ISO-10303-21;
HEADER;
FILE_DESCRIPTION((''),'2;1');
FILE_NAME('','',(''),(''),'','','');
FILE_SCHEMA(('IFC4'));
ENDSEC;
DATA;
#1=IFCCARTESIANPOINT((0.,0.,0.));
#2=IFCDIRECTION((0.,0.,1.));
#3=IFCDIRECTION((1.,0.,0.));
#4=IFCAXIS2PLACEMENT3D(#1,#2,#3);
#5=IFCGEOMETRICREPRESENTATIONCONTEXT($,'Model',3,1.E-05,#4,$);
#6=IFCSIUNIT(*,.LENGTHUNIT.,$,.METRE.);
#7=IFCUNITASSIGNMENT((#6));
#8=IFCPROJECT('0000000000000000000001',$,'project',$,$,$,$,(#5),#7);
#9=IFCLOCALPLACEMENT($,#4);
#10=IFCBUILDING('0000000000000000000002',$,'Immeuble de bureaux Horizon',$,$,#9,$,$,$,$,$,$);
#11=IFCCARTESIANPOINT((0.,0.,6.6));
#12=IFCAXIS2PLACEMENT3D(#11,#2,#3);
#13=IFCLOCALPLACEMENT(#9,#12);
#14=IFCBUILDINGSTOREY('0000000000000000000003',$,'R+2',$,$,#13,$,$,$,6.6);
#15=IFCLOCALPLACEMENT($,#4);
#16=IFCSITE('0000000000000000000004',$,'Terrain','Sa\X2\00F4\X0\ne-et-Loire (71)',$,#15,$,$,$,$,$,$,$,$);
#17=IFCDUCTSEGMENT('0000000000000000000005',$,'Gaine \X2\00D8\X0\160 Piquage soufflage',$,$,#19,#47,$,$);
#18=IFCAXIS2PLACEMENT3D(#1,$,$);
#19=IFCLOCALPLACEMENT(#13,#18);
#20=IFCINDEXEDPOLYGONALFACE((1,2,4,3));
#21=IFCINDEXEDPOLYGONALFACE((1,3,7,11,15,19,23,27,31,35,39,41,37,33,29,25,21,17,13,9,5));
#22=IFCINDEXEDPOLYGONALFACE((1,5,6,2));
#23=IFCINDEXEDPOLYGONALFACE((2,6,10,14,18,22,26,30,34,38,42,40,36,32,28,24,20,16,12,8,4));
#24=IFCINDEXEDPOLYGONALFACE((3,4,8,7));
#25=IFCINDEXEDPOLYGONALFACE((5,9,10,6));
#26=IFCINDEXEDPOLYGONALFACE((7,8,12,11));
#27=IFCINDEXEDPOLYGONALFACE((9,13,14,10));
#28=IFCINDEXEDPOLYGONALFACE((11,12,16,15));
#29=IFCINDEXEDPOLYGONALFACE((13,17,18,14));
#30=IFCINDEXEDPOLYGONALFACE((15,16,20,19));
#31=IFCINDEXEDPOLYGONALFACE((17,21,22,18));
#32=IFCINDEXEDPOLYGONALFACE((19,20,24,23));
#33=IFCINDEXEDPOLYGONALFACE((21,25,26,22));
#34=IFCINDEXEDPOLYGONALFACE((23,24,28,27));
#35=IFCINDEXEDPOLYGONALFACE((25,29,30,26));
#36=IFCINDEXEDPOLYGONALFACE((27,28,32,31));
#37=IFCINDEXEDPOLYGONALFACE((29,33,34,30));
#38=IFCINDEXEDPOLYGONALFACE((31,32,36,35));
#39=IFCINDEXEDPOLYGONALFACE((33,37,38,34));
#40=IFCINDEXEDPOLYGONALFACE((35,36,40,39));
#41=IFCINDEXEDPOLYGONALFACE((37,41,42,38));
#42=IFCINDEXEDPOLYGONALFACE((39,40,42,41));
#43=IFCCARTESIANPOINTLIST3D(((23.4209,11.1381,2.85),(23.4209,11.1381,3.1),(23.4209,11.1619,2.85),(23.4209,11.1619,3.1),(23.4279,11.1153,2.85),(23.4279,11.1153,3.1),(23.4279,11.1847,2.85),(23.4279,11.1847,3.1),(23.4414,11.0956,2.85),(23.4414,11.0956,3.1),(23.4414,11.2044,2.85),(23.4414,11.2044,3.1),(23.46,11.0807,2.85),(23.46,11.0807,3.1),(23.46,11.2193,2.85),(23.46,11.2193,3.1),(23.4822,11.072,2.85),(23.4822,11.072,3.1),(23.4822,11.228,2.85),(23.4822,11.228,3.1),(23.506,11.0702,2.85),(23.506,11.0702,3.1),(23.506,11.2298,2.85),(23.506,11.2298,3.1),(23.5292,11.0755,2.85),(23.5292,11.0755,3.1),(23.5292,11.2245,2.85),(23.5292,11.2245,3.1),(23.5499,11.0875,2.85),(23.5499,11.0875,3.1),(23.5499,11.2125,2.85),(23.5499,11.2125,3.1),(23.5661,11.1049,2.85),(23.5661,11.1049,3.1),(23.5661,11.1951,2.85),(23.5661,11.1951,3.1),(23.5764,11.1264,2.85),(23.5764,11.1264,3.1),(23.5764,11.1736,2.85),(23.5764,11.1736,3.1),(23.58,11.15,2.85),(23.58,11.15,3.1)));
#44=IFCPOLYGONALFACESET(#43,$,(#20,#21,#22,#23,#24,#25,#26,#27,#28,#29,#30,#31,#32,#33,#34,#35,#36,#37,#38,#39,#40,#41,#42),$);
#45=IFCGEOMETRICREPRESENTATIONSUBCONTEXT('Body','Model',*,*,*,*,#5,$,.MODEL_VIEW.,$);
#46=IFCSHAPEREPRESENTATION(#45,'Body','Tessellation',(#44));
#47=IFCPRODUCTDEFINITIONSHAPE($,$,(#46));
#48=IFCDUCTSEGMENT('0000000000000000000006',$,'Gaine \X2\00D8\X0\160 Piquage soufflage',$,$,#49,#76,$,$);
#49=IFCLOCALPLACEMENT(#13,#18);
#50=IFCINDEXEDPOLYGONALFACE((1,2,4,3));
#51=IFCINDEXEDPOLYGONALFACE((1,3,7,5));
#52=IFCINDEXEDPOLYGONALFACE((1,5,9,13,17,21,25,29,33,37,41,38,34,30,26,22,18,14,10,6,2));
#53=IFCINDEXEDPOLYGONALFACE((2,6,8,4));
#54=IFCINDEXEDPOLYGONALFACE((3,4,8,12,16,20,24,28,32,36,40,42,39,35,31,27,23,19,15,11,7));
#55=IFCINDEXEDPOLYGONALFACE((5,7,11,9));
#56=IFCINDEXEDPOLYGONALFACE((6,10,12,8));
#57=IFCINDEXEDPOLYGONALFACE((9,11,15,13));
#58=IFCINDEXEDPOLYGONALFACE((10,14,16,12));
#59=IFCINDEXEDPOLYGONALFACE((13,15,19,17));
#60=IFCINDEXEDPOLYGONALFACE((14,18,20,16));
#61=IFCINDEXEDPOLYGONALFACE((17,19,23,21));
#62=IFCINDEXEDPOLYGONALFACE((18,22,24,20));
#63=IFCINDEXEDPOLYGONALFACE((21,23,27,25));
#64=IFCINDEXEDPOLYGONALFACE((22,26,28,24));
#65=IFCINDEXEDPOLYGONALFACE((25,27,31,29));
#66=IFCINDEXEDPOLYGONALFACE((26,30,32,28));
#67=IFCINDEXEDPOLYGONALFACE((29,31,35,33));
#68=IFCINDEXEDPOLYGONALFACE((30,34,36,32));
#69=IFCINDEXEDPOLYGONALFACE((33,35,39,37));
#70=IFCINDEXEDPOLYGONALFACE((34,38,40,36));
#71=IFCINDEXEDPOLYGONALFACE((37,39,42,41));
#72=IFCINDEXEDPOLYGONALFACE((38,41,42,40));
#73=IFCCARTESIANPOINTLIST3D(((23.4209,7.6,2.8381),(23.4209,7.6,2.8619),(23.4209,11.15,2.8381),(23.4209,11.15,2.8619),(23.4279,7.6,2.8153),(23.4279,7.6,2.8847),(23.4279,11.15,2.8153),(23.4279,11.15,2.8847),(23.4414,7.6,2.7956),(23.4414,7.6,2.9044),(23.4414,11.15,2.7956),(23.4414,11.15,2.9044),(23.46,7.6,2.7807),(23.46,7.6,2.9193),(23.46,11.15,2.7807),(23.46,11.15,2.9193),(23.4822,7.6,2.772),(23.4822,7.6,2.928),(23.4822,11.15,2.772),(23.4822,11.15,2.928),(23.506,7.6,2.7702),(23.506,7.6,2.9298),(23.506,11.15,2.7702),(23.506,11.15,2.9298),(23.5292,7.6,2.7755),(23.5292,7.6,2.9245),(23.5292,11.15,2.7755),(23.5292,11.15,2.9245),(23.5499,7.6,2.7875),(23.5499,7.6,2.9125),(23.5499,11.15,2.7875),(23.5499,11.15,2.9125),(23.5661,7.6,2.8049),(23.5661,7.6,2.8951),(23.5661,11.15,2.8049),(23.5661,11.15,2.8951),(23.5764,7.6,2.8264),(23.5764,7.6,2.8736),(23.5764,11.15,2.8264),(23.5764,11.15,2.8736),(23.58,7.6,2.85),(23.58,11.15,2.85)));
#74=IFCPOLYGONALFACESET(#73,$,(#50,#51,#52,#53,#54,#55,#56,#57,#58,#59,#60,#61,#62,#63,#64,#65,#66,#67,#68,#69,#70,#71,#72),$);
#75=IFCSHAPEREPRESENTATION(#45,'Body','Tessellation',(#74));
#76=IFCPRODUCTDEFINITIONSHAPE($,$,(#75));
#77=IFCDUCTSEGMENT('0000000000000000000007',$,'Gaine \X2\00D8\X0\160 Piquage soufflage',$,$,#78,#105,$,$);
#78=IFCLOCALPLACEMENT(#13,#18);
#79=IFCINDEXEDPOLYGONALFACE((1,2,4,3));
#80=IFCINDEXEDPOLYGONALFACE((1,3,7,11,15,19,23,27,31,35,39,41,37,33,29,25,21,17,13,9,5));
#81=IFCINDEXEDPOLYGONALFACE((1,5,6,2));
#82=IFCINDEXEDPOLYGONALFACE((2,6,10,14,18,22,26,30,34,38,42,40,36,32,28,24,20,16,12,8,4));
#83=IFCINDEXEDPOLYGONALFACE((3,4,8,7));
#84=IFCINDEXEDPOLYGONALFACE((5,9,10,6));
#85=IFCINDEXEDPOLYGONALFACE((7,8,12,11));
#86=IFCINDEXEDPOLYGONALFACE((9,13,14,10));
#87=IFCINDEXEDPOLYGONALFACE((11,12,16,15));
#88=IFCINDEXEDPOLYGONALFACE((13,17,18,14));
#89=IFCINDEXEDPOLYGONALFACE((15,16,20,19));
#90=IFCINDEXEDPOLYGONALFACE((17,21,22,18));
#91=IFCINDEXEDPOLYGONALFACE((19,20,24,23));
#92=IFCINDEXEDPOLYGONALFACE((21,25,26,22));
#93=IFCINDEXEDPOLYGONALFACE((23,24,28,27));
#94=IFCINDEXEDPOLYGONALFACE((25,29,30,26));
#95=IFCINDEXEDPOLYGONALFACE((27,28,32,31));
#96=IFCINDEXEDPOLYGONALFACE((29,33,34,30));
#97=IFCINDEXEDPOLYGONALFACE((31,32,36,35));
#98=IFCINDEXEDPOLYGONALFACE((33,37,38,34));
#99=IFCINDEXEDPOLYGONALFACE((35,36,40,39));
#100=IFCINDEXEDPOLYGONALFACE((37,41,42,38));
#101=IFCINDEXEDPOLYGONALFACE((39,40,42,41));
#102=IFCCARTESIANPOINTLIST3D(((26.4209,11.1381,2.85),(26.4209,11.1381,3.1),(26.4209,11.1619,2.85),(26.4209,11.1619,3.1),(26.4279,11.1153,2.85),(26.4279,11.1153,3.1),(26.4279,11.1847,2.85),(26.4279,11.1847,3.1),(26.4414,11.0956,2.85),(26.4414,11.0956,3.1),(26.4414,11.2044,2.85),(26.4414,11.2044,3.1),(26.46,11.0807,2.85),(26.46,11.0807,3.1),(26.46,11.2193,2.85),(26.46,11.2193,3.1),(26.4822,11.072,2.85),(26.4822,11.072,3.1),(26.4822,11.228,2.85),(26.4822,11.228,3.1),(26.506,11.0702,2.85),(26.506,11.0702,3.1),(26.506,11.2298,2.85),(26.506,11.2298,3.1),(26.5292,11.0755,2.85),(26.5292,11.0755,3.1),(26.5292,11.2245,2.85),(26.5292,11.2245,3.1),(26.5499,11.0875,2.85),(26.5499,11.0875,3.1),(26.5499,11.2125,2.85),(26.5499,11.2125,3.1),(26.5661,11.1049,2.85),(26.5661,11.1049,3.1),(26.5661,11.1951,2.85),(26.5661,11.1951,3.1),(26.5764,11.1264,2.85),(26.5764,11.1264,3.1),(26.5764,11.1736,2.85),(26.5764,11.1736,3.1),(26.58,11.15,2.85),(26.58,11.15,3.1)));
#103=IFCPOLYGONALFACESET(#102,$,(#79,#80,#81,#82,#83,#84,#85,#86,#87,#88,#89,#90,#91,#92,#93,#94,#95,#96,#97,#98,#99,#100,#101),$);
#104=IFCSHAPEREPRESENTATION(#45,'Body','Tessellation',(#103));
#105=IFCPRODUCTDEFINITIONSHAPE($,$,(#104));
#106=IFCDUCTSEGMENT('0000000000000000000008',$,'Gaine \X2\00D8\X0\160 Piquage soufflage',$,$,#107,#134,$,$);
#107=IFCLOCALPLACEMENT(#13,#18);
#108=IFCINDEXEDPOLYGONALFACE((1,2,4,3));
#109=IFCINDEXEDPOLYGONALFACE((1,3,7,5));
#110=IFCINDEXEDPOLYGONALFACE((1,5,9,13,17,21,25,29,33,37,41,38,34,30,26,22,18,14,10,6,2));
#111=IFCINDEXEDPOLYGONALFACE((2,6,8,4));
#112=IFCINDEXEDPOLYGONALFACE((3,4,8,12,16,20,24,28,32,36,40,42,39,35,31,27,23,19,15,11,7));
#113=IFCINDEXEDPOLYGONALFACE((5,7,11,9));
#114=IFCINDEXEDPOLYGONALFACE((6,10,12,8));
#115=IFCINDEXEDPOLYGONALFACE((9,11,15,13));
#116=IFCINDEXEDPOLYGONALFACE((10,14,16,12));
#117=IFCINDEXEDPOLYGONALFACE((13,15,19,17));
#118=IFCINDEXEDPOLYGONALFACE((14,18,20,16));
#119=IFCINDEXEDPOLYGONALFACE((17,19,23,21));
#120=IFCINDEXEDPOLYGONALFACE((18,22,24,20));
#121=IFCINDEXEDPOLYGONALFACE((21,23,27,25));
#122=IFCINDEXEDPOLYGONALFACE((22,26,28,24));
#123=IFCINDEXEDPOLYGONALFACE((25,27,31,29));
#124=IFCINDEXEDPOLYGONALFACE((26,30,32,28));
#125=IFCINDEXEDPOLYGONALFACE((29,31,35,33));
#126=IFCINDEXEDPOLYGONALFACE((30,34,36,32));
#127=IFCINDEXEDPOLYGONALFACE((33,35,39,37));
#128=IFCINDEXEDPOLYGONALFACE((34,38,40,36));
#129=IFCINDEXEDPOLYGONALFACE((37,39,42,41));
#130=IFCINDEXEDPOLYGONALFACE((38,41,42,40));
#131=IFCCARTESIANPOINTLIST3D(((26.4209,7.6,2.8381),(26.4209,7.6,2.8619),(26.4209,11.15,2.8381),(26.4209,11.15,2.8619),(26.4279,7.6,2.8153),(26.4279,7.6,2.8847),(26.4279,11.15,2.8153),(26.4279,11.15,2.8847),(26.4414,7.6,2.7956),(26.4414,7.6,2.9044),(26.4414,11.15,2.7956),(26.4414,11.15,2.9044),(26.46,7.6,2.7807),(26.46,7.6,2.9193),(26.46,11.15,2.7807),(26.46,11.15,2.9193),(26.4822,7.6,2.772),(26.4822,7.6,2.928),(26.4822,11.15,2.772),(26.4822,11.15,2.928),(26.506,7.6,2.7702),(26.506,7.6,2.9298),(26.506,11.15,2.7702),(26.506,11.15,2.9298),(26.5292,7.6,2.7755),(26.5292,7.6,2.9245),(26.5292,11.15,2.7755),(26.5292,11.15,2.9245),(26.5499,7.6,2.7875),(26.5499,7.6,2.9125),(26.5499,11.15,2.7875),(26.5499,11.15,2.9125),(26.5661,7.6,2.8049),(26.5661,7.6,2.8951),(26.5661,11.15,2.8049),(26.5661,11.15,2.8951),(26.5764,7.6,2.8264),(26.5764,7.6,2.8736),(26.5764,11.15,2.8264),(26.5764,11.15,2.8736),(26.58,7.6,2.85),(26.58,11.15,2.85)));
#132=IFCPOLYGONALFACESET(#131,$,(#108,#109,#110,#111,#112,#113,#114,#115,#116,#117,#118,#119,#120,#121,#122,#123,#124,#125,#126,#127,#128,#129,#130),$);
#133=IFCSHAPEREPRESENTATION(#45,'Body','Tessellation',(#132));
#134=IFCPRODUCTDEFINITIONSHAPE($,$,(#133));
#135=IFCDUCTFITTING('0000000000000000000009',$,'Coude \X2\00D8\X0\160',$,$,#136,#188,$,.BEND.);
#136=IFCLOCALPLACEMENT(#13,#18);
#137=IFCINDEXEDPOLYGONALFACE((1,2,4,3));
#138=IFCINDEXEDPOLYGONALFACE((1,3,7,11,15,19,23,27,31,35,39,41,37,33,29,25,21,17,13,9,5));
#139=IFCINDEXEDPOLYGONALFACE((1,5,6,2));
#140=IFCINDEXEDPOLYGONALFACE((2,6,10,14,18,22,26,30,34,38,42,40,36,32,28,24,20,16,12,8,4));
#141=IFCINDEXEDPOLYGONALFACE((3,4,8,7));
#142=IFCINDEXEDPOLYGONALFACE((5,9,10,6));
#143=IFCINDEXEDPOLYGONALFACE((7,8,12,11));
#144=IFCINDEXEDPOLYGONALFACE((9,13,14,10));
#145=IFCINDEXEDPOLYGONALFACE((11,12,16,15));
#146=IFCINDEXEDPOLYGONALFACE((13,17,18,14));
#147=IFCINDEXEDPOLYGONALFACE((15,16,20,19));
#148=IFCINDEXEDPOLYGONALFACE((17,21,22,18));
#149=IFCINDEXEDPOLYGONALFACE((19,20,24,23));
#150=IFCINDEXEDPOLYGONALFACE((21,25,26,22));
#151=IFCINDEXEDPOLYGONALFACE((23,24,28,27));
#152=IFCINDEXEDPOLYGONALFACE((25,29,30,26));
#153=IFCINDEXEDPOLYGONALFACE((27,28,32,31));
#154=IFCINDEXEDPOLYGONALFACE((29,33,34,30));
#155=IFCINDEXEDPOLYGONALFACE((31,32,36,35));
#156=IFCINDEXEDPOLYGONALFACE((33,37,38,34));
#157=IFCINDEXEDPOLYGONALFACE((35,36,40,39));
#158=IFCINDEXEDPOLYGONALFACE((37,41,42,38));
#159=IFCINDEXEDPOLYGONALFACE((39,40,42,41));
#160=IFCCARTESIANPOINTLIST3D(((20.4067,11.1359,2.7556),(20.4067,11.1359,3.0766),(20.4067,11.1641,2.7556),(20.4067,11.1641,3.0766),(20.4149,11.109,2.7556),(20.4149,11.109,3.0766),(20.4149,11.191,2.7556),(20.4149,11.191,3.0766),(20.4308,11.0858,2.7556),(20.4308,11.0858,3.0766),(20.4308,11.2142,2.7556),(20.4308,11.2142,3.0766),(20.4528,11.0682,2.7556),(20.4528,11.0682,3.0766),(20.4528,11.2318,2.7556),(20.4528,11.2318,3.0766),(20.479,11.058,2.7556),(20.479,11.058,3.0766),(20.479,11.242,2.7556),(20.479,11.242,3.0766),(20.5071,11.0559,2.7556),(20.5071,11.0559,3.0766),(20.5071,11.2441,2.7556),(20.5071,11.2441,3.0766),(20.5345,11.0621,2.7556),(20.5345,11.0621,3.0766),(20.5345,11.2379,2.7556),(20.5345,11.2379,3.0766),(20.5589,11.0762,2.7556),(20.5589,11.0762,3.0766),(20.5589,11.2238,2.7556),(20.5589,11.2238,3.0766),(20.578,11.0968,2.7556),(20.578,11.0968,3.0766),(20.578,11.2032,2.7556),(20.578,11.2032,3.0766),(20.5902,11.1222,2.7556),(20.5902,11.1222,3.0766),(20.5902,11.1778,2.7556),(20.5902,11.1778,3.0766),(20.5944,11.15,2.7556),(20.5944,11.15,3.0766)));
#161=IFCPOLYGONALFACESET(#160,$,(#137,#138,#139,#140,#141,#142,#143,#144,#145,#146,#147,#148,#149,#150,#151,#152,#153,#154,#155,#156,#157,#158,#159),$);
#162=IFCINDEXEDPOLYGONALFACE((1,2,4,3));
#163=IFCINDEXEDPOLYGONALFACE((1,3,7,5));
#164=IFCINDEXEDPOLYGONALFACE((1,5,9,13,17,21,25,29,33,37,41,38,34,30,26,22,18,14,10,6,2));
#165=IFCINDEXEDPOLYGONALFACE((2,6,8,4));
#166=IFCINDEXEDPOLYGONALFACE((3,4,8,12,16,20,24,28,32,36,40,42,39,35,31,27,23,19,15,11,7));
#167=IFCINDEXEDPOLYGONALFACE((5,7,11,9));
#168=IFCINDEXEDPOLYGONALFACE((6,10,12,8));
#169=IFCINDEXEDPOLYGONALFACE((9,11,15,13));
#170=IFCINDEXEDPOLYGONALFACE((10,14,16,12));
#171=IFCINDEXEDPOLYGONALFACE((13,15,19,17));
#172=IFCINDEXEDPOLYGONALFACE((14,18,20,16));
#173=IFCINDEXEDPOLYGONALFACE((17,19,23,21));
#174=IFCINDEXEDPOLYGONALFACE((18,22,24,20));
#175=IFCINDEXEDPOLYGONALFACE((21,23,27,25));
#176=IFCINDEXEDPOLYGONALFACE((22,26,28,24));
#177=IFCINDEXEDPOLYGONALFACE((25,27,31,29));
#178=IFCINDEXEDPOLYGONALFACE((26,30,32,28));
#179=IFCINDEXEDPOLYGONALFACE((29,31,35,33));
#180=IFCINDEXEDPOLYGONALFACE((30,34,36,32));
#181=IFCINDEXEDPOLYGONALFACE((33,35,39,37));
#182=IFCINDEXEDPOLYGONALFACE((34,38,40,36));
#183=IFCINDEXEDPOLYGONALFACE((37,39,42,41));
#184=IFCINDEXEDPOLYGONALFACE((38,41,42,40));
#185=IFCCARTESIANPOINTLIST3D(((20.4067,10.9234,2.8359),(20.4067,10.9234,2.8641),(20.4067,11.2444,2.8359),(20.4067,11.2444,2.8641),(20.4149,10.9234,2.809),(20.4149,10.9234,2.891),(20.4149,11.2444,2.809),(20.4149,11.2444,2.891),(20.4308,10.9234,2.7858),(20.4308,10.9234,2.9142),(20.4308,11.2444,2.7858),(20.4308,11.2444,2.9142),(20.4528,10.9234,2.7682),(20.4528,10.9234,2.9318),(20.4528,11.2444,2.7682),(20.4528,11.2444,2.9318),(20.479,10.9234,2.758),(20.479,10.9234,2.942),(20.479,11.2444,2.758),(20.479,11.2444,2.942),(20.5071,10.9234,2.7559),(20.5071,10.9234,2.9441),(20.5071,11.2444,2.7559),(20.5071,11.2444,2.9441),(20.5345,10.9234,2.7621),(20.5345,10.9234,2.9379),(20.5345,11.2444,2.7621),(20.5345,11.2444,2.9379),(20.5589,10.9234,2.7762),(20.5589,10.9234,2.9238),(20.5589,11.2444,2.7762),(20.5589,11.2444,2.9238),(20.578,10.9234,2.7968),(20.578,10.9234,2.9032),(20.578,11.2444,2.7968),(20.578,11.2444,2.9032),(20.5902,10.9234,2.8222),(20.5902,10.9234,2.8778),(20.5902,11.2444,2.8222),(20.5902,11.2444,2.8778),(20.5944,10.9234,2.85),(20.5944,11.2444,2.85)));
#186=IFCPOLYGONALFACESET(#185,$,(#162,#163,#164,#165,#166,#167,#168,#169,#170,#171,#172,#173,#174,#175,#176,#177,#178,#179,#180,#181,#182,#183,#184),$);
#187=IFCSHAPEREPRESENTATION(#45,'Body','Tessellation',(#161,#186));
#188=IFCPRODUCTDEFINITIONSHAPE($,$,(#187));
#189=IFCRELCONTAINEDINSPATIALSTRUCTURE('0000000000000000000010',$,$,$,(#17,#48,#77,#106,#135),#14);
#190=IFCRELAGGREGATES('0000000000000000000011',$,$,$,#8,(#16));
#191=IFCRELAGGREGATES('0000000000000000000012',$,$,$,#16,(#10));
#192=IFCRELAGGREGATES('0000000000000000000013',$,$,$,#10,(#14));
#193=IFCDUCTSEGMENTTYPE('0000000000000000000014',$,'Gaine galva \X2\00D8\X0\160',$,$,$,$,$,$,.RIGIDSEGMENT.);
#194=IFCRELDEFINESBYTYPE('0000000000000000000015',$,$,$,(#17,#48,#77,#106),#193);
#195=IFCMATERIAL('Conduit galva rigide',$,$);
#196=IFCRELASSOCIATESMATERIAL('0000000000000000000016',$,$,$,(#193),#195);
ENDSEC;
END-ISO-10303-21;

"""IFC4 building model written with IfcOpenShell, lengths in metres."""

from ifc_helpers import new_model, si_unit, frame, origin_with_axes, place, context, subcontext, project, spatial, circle, extrude, material, type_object, element, save


model = new_model("IFC4")

# Units and contexts
model_context = context("Model", 3, precision=1e-05, world=origin_with_axes())
body_context = subcontext(model_context, "Body", "Model", "MODEL_VIEW")
ifc_project = project(units=[si_unit("LENGTHUNIT", "METRE")], contexts=[model_context])

# Site, building, storey
site_placement = place(None, origin_with_axes())
site = spatial("IfcSite", under=ifc_project, at=site_placement, Name="Terrain", Description="Saône-et-Loire (71)")
building_placement = place(None, origin_with_axes())
building = spatial("IfcBuilding", under=site, at=building_placement, Name="Immeuble de bureaux Horizon")
storey_placement = place(building_placement, frame((0.0, 0.0, 6.6), z_axis=(0.0, 0.0, 1.0), x_axis=(1.0, 0.0, 0.0)))
storey = spatial("IfcBuildingStorey", under=building, at=storey_placement, Name="R+2", Elevation=6.6)

# Duct segments
ifc_material_1 = material(Name="Conduit galva rigide")
duct_segment_type = type_object("IfcDuctSegmentType", Name="Gaine galva Ø160", PredefinedType="RIGIDSEGMENT", material=ifc_material_1)
duct_segment_1_placement = place(storey_placement, frame((23.5, 11.15, 3.1), z_axis=(0.0, 0.0, -1.0), x_axis=(1.0, 0.0, 0.0)))
element("IfcDuctSegment", 1, at=duct_segment_1_placement, inside=storey, type_object=duct_segment_type, Name="Gaine Ø160 Piquage soufflage", context=body_context, shape_type="SweptSolid", body=[
    extrude(circle(Radius=0.08), origin_with_axes(), (0.0, 0.0, 1.0), 0.25),
])
duct_segment_2_placement = place(storey_placement, frame((23.5, 11.15, 2.85), z_axis=(0.0, -1.0, 0.0), x_axis=(1.0, 0.0, 0.0)))
element("IfcDuctSegment", 2, at=duct_segment_2_placement, inside=storey, type_object=duct_segment_type, Name="Gaine Ø160 Piquage soufflage", context=body_context, shape_type="SweptSolid", body=[
    extrude(circle(Radius=0.08), origin_with_axes(), (0.0, 0.0, 1.0), 3.55),
])
duct_segment_3_placement = place(storey_placement, frame((26.5, 11.15, 3.1), z_axis=(0.0, 0.0, -1.0), x_axis=(1.0, 0.0, 0.0)))
element("IfcDuctSegment", 3, at=duct_segment_3_placement, inside=storey, type_object=duct_segment_type, Name="Gaine Ø160 Piquage soufflage", context=body_context, shape_type="SweptSolid", body=[
    extrude(circle(Radius=0.08), origin_with_axes(), (0.0, 0.0, 1.0), 0.25),
])
duct_segment_4_placement = place(storey_placement, frame((26.5, 11.15, 2.85), z_axis=(0.0, -1.0, 0.0), x_axis=(1.0, 0.0, 0.0)))
element("IfcDuctSegment", 4, at=duct_segment_4_placement, inside=storey, type_object=duct_segment_type, Name="Gaine Ø160 Piquage soufflage", context=body_context, shape_type="SweptSolid", body=[
    extrude(circle(Radius=0.08), origin_with_axes(), (0.0, 0.0, 1.0), 3.55),
])

# Duct fitting
duct_fitting_1_placement = place(storey_placement, frame((20.5, 11.15, 2.85), z_axis=(0.0, 0.0, 1.0), x_axis=(1.0, 0.0, 0.0)))
element("IfcDuctFitting", 5, at=duct_fitting_1_placement, inside=storey, Name="Coude Ø160", PredefinedType="BEND", context=body_context, shape_type="SweptSolid", body=[
    extrude(circle(Radius=0.0944), frame((0.0, 0.0, -0.0944), z_axis=(0.0, 0.0, 1.0), x_axis=(1.0, 0.0, 0.0)), (0.0, 0.0, 1.0), 0.321),
    extrude(circle(Radius=0.0944), frame((0.0, 0.0944, 0.0), z_axis=(0.0, -1.0, 0.0), x_axis=(1.0, 0.0, 0.0)), (0.0, 0.0, 1.0), 0.321),
])

save(model, "model.ifc")
